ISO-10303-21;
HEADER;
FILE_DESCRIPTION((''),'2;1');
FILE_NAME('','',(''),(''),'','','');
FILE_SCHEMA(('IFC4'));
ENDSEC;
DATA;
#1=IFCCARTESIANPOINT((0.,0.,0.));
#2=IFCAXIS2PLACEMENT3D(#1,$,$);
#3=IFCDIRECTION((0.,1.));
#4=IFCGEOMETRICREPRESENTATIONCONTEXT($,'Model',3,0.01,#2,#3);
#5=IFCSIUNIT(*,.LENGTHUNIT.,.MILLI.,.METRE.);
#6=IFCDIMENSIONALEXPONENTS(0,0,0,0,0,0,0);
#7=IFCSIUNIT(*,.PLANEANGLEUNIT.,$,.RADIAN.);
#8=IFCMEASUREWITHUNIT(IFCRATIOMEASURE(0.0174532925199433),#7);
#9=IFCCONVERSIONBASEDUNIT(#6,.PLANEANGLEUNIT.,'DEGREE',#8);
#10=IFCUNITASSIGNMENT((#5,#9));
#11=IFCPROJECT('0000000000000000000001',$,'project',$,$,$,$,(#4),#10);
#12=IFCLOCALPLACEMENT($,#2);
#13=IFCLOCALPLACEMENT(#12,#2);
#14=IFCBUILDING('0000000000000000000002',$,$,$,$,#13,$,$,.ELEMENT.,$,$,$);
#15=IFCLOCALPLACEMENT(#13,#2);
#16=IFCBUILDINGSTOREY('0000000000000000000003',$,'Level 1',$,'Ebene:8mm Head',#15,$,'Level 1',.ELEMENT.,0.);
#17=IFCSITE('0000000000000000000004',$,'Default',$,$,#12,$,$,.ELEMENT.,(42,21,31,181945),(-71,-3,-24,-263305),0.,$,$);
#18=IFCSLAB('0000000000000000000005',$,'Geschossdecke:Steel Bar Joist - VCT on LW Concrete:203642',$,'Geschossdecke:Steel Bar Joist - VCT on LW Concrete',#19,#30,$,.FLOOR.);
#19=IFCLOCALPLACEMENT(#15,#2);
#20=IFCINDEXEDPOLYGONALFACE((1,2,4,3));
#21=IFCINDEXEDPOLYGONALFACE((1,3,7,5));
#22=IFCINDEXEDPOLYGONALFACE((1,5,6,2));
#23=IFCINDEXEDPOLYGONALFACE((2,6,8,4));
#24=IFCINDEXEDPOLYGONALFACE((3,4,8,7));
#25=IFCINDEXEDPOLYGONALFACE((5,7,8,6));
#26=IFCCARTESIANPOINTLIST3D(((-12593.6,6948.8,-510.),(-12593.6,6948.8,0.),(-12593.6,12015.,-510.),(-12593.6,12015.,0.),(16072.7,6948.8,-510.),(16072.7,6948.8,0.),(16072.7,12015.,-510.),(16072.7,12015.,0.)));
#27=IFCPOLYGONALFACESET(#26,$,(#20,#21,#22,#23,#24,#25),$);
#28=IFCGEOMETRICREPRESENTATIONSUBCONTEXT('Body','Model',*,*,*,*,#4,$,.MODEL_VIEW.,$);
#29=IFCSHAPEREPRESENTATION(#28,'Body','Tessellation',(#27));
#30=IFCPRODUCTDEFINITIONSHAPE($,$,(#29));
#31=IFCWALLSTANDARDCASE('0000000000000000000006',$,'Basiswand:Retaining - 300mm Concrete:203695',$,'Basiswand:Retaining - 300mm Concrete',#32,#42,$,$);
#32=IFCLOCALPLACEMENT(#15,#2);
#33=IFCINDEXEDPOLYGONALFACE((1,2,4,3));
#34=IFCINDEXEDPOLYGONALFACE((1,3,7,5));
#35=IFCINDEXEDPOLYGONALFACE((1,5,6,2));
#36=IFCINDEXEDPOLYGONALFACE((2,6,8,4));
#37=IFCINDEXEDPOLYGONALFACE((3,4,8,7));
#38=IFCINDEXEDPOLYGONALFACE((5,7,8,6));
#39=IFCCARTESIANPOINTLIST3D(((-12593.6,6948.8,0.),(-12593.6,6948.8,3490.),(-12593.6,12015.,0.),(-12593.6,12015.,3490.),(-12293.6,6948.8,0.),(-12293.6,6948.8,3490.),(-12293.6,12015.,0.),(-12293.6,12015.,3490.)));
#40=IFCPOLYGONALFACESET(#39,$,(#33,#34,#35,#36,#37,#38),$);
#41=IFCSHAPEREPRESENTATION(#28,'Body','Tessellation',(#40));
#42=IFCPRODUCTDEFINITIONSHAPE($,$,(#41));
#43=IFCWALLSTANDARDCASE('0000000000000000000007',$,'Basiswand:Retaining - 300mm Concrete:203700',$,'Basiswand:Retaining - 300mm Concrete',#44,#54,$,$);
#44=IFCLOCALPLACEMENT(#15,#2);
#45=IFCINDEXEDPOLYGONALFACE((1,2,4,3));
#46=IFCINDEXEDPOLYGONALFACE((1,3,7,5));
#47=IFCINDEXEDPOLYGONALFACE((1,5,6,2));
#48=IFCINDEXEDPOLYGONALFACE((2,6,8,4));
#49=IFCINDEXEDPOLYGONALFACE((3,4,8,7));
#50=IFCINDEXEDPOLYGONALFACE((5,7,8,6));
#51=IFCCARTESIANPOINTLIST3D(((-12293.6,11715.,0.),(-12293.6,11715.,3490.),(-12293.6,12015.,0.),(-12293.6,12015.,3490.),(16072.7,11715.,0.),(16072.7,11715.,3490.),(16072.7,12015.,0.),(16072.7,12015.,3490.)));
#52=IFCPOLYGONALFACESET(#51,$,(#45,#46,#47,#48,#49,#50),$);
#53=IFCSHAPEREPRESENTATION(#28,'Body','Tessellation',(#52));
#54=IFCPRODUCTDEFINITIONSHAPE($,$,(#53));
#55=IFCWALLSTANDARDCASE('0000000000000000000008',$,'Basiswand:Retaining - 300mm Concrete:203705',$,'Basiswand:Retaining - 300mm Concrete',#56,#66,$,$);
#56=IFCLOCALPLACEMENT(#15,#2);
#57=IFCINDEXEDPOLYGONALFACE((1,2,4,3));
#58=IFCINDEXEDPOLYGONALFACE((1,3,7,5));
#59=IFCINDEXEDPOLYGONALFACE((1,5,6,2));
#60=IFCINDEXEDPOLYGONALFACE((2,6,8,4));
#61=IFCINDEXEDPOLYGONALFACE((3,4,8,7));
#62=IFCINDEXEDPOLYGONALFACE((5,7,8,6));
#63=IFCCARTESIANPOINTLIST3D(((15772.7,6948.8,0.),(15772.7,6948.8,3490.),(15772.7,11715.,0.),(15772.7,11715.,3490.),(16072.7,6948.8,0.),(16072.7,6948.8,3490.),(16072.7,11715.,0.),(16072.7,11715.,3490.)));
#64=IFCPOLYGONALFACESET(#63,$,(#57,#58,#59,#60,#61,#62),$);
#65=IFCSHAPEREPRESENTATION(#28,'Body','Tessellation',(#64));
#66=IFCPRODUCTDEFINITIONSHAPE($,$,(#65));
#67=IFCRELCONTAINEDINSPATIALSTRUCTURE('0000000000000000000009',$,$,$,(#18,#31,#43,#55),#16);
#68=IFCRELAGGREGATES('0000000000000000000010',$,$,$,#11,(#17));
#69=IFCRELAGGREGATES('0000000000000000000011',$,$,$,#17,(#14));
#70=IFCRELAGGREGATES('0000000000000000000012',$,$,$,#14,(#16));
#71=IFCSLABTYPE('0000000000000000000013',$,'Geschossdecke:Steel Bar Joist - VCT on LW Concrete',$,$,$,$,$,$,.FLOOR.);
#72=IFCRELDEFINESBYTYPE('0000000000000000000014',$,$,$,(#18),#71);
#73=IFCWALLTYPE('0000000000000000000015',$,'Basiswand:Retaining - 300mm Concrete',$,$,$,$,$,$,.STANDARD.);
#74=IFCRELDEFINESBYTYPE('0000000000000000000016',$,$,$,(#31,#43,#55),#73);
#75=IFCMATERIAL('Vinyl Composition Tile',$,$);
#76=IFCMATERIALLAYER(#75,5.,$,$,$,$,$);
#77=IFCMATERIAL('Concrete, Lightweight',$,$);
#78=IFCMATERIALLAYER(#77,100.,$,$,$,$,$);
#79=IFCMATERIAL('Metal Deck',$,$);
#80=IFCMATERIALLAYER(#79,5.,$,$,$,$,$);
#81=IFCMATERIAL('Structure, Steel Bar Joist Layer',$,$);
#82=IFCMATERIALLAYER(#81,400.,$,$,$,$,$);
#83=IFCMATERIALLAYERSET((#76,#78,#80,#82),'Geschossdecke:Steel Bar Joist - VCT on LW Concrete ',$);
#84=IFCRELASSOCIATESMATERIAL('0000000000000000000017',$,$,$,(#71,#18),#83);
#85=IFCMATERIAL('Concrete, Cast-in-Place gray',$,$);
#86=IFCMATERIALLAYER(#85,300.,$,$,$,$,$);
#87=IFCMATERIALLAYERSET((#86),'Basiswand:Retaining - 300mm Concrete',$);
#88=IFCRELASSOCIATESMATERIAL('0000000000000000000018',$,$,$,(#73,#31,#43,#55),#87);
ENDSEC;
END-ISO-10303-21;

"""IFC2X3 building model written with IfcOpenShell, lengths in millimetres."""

from ifc_helpers import new_model, entity, si_unit, converted_unit, direction, frame, frame_2d, origin, place, context, subcontext, project, spatial, polyline, rectangle, extrude, clip, bounded_halfspace, material, layer, layer_set, layer_usage, type_object, element, save


model = new_model("IFC2X3")

# Units and contexts
model_context = context("Model", 3, precision=0.01, world=origin(), true_north=direction((0.0, 1.0)))
body_context = subcontext(model_context, "Body", "Model", "MODEL_VIEW")
ifc_project = project(units=[si_unit("LENGTHUNIT", "METRE", prefix="MILLI"), converted_unit("PLANEANGLEUNIT", "DEGREE", entity("IfcRatioMeasure", 0.0174532925199433), si_unit("PLANEANGLEUNIT", "RADIAN"), dimensions=[0, 0, 0, 0, 0, 0, 0])], contexts=[model_context])

# Site, building, storey
site_placement = place(None, origin())
site = spatial("IfcSite", under=ifc_project, at=site_placement, Name="Default", CompositionType="ELEMENT", RefLatitude=(42, 21, 31, 181945), RefLongitude=(-71, -3, -24, -263305), RefElevation=0.0)
building_placement = place(site_placement, origin())
building = spatial("IfcBuilding", under=site, at=building_placement, CompositionType="ELEMENT")
storey_placement = place(building_placement, origin())
storey = spatial("IfcBuildingStorey", under=building, at=storey_placement, Name="Level 1", ObjectType="Ebene:8mm Head", LongName="Level 1", CompositionType="ELEMENT", Elevation=0.0)

# Slab
ifc_material_1 = material(Name="Vinyl Composition Tile")
ifc_layer_1 = layer(ifc_material_1, 5.0)
ifc_material_2 = material(Name="Concrete, Lightweight")
ifc_layer_2 = layer(ifc_material_2, 100.0)
ifc_material_3 = material(Name="Metal Deck")
ifc_layer_3 = layer(ifc_material_3, 5.0)
ifc_material_4 = material(Name="Structure, Steel Bar Joist Layer")
ifc_layer_4 = layer(ifc_material_4, 400.0)
ifc_layer_set_1 = layer_set([ifc_layer_1, ifc_layer_2, ifc_layer_3, ifc_layer_4], Name="Geschossdecke:Steel Bar Joist - VCT on LW Concrete ")
ifc_layer_usage_1 = layer_usage(ifc_layer_set_1, "AXIS3", "POSITIVE", 0.0)
slab_type = type_object("IfcSlabType", Name="Geschossdecke:Steel Bar Joist - VCT on LW Concrete", PredefinedType="FLOOR", material=ifc_layer_set_1)
slab_placement = place(storey_placement, origin())
element("IfcSlab", 1, at=slab_placement, inside=storey, type_object=slab_type, material=ifc_layer_usage_1, Name="Geschossdecke:Steel Bar Joist - VCT on LW Concrete:203642", ObjectType="Geschossdecke:Steel Bar Joist - VCT on LW Concrete", PredefinedType="FLOOR", context=body_context, shape_type="SweptSolid", body=[
    extrude(rectangle(XDim=5066.3, YDim=28666.3, at=frame_2d((0.0, 0.0), x_axis=(1.0, 0.0))), frame((1739.6, 9481.9, 0.0), z_axis=(0.0, 0.0, -1.0), x_axis=(0.0, 1.0, 0.0)), (0.0, 0.0, 1.0), 510.0),
])

# Walls
ifc_material_5 = material(Name="Concrete, Cast-in-Place gray")
ifc_layer_5 = layer(ifc_material_5, 300.0)
ifc_layer_set_2 = layer_set([ifc_layer_5], Name="Basiswand:Retaining - 300mm Concrete")
ifc_layer_usage_2 = layer_usage(ifc_layer_set_2, "AXIS2", "NEGATIVE", 150.0)
wall_type = type_object("IfcWallType", Name="Basiswand:Retaining - 300mm Concrete", PredefinedType="STANDARD", material=ifc_layer_set_2)
wall_1_placement = place(storey_placement, frame((-12443.6, 6948.8, 0.0), z_axis=(0.0, 0.0, 1.0), x_axis=(0.0, 1.0, 0.0)))
element("IfcWallStandardCase", 2, at=wall_1_placement, inside=storey, type_object=wall_type, material=ifc_layer_usage_2, Name="Basiswand:Retaining - 300mm Concrete:203695", ObjectType="Basiswand:Retaining - 300mm Concrete", context=body_context, shape_type="Clipping", body=[
    clip(extrude(rectangle(XDim=5066.3, YDim=300.0, at=frame_2d((2533.1, 0.0), x_axis=(-1.0, 0.0))), origin(), (0.0, 0.0, 1.0), 3490.0), bounded_halfspace(frame((0.0, -150.0, 3490.0), z_axis=(0.0, 0.0, -1.0), x_axis=(-1.0, 0.0, 0.0)), True, frame((0.0, -150.0, 3490.0)), polyline([(0.0, 0.0), (4766.3, 0.0), (5066.3, 0.0), (5066.3, 300.0), (0.0, 300.0), (0.0, 0.0)]))),
])
ifc_layer_usage_3 = layer_usage(ifc_layer_set_2, "AXIS2", "NEGATIVE", 150.0)
wall_2_placement = place(storey_placement, frame((-12293.6, 11865.0, 0.0)))
element("IfcWallStandardCase", 3, at=wall_2_placement, inside=storey, type_object=wall_type, material=ifc_layer_usage_3, Name="Basiswand:Retaining - 300mm Concrete:203700", ObjectType="Basiswand:Retaining - 300mm Concrete", context=body_context, shape_type="Clipping", body=[
    clip(extrude(rectangle(XDim=28366.3, YDim=300.0, at=frame_2d((14183.1, 0.0), x_axis=(-1.0, 0.0))), origin(), (0.0, 0.0, 1.0), 3490.0), bounded_halfspace(frame((0.0, -150.0, 3490.0), z_axis=(0.0, 0.0, -1.0), x_axis=(0.0, -1.0, 0.0)), True, frame((0.0, -150.0, 3490.0)), polyline([(0.0, 0.0), (28066.3, 0.0), (28366.3, 0.0), (28366.3, 300.0), (0.0, 300.0), (0.0, 0.0)]))),
])
ifc_layer_usage_4 = layer_usage(ifc_layer_set_2, "AXIS2", "NEGATIVE", 150.0)
wall_3_placement = place(storey_placement, frame((15922.7, 11715.0, 0.0), z_axis=(0.0, 0.0, 1.0), x_axis=(0.0, -1.0, 0.0)))
element("IfcWallStandardCase", 4, at=wall_3_placement, inside=storey, type_object=wall_type, material=ifc_layer_usage_4, Name="Basiswand:Retaining - 300mm Concrete:203705", ObjectType="Basiswand:Retaining - 300mm Concrete", context=body_context, shape_type="Clipping", body=[
    clip(extrude(rectangle(XDim=4766.3, YDim=300.0, at=frame_2d((2383.1, 0.0), x_axis=(-1.0, 0.0))), origin(), (0.0, 0.0, 1.0), 3490.0), bounded_halfspace(frame((0.0, -150.0, 3490.0), z_axis=(0.0, 0.0, -1.0), x_axis=(1.0, 0.0, 0.0)), True, frame((0.0, -150.0, 3490.0)), polyline([(0.0, 0.0), (4766.3, 0.0), (4766.3, 300.0), (0.0, 300.0), (0.0, 0.0)]))),
])

save(model, "model.ifc")
